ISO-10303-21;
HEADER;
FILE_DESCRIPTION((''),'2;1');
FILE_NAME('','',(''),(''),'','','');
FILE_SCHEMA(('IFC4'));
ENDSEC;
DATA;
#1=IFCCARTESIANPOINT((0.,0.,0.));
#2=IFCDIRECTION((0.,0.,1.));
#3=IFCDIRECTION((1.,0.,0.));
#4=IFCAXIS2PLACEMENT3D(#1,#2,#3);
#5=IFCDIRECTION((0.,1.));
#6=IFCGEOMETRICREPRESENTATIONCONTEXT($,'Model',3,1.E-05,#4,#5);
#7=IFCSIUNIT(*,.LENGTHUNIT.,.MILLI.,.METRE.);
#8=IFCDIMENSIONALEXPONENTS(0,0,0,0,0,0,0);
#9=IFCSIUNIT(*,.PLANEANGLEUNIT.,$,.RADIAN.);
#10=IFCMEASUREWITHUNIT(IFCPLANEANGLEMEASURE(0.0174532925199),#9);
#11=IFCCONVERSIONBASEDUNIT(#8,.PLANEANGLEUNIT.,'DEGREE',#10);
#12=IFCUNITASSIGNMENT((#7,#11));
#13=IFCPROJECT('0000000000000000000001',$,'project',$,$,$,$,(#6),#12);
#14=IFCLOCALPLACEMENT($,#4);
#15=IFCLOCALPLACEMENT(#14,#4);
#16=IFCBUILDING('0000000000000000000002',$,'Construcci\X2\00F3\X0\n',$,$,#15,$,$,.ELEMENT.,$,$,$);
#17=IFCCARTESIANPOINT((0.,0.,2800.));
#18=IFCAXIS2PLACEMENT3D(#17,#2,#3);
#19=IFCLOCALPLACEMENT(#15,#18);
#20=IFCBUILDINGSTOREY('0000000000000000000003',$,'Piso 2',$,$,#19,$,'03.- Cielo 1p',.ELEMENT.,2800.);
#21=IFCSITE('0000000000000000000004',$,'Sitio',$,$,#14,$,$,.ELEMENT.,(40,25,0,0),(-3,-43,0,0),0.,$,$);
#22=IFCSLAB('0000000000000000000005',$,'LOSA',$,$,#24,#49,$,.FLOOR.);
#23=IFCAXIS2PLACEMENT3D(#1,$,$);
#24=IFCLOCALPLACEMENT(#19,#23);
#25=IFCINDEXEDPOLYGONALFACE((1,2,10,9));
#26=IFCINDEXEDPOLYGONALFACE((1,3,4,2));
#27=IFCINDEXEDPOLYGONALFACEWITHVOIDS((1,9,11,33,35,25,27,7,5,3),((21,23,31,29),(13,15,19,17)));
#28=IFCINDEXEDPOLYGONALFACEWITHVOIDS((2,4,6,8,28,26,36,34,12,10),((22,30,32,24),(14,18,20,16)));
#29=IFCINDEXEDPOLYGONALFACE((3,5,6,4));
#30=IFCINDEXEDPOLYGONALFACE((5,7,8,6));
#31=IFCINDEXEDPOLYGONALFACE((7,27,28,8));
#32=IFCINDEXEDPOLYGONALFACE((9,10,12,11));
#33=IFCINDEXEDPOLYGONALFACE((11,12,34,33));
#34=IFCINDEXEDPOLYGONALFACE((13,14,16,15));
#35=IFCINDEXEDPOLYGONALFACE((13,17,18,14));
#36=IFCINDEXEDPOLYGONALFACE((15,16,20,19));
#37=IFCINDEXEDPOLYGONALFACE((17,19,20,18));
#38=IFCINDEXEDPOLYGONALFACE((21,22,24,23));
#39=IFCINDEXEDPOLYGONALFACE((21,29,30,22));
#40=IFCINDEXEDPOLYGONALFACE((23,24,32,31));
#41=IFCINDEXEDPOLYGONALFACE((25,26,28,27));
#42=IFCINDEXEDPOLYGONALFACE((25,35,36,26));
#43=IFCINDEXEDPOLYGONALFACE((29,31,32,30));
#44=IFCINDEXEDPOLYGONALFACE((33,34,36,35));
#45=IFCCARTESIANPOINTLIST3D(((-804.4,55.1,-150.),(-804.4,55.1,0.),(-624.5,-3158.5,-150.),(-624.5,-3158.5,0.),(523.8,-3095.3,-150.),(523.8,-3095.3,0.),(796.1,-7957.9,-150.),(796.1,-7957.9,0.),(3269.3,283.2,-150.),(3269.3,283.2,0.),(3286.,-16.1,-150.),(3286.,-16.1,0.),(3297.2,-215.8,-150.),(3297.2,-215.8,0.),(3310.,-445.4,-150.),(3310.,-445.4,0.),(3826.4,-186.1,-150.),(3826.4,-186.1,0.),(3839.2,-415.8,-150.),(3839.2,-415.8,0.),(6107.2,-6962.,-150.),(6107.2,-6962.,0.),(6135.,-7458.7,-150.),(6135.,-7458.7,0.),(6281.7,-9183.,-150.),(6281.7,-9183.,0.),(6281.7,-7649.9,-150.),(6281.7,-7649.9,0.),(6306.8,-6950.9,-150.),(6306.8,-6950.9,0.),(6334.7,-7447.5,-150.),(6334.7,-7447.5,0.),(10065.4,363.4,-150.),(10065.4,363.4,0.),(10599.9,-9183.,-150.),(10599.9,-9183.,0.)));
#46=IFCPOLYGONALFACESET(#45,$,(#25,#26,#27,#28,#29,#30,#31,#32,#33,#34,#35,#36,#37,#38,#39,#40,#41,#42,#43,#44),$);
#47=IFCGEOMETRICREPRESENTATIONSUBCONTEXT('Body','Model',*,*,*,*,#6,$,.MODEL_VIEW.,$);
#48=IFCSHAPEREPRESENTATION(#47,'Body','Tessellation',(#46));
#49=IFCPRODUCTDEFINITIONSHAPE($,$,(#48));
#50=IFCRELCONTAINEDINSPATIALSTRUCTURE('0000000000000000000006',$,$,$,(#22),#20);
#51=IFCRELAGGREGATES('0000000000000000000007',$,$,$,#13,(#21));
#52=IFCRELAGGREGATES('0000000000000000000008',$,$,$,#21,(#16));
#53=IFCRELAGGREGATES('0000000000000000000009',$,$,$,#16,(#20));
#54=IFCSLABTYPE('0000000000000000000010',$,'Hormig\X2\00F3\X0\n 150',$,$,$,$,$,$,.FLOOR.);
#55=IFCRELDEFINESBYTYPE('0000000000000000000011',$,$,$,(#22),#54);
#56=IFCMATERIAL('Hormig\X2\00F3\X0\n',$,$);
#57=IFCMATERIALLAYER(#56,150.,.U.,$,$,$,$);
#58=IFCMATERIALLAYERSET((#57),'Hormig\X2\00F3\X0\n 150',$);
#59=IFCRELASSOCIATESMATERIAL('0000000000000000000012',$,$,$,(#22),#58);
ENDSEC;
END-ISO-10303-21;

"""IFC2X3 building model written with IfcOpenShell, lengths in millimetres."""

from ifc_helpers import new_model, entity, si_unit, converted_unit, direction, frame, origin_with_axes, place, context, subcontext, project, spatial, polyline, outline, extrude, material, layer, layer_set, layer_usage, type_object, element, save


model = new_model("IFC2X3")

# Units and contexts
model_context = context("Model", 3, precision=1e-05, world=origin_with_axes(), true_north=direction((0.0, 1.0)))
body_context = subcontext(model_context, "Body", "Model", "MODEL_VIEW")
ifc_project = project(units=[si_unit("LENGTHUNIT", "METRE", prefix="MILLI"), converted_unit("PLANEANGLEUNIT", "DEGREE", entity("IfcPlaneAngleMeasure", 0.0174532925199), si_unit("PLANEANGLEUNIT", "RADIAN"), dimensions=[0, 0, 0, 0, 0, 0, 0])], contexts=[model_context])

# Site, building, storey
site_placement = place(None, origin_with_axes())
site = spatial("IfcSite", under=ifc_project, at=site_placement, Name="Sitio", CompositionType="ELEMENT", RefLatitude=(40, 25, 0, 0), RefLongitude=(-3, -43, 0, 0), RefElevation=0.0)
building_placement = place(site_placement, origin_with_axes())
building = spatial("IfcBuilding", under=site, at=building_placement, Name="Construcción", CompositionType="ELEMENT")
storey_placement = place(building_placement, frame((0.0, 0.0, 2800.0), z_axis=(0.0, 0.0, 1.0), x_axis=(1.0, 0.0, 0.0)))
storey = spatial("IfcBuildingStorey", under=building, at=storey_placement, Name="Piso 2", LongName="03.- Cielo 1p", CompositionType="ELEMENT", Elevation=2800.0)

# Slab, openings
ifc_material = material(Name="Hormigón")
ifc_layer = layer(ifc_material, 150.0, ventilated="UNKNOWN")
ifc_layer_set = layer_set([ifc_layer], Name="Hormigón 150")
ifc_layer_usage = layer_usage(ifc_layer_set, "AXIS3", "NEGATIVE", 150.0)
slab_type = type_object("IfcSlabType", Name="Hormigón 150", PredefinedType="FLOOR")
slab_placement = place(storey_placement, frame((-804.4, 55.1, 0.0), z_axis=(0.0, 0.0, 1.0), x_axis=(1.0, 0.0, 0.0)))
slab = element("IfcSlab", 1, at=slab_placement, inside=storey, type_object=slab_type, material=ifc_layer_usage, Name="LOSA", PredefinedType="FLOOR", context=body_context, shape_type="SweptSolid", body=[
    extrude(outline(polyline([(0.0, 0.0), (179.9, -3213.6), (1328.2, -3150.4), (1600.4, -8013.1), (7086.0, -7705.0), (7086.0, -9238.1), (11404.2, -9238.1), (10869.8, 308.3), (4090.4, -71.2), (4073.6, 228.1), (0.0, 0.0)])), frame((0.0, 0.0, -150.0), z_axis=(0.0, 0.0, 1.0), x_axis=(1.0, 0.0, 0.0)), (0.0, 0.0, 1.0), 150.0),
])
opening_1_placement = place(slab_placement, origin_with_axes())
element("IfcOpeningElement", 2, at=opening_1_placement, cuts=slab, context=body_context, shape_type="SweptSolid", body=[
    extrude(outline(polyline([(4101.5, -270.9), (4114.4, -500.5), (4643.6, -470.9), (4630.7, -241.3), (4101.5, -270.9)])), frame((0.0, 0.0, -150.0), z_axis=(0.0, 0.0, 1.0), x_axis=(1.0, 0.0, 0.0)), (0.0, 0.0, 1.0), 150.0),
])
opening_2_placement = place(slab_placement, origin_with_axes())
element("IfcOpeningElement", 3, at=opening_2_placement, cuts=slab, context=body_context, shape_type="SweptSolid", body=[
    extrude(outline(polyline([(6939.3, -7513.8), (7139.0, -7502.6), (7111.2, -7006.0), (6911.5, -7017.2), (6939.3, -7513.8)])), frame((0.0, 0.0, -150.0), z_axis=(0.0, 0.0, 1.0), x_axis=(1.0, 0.0, 0.0)), (0.0, 0.0, 1.0), 150.0),
])

save(model, "model.ifc")
